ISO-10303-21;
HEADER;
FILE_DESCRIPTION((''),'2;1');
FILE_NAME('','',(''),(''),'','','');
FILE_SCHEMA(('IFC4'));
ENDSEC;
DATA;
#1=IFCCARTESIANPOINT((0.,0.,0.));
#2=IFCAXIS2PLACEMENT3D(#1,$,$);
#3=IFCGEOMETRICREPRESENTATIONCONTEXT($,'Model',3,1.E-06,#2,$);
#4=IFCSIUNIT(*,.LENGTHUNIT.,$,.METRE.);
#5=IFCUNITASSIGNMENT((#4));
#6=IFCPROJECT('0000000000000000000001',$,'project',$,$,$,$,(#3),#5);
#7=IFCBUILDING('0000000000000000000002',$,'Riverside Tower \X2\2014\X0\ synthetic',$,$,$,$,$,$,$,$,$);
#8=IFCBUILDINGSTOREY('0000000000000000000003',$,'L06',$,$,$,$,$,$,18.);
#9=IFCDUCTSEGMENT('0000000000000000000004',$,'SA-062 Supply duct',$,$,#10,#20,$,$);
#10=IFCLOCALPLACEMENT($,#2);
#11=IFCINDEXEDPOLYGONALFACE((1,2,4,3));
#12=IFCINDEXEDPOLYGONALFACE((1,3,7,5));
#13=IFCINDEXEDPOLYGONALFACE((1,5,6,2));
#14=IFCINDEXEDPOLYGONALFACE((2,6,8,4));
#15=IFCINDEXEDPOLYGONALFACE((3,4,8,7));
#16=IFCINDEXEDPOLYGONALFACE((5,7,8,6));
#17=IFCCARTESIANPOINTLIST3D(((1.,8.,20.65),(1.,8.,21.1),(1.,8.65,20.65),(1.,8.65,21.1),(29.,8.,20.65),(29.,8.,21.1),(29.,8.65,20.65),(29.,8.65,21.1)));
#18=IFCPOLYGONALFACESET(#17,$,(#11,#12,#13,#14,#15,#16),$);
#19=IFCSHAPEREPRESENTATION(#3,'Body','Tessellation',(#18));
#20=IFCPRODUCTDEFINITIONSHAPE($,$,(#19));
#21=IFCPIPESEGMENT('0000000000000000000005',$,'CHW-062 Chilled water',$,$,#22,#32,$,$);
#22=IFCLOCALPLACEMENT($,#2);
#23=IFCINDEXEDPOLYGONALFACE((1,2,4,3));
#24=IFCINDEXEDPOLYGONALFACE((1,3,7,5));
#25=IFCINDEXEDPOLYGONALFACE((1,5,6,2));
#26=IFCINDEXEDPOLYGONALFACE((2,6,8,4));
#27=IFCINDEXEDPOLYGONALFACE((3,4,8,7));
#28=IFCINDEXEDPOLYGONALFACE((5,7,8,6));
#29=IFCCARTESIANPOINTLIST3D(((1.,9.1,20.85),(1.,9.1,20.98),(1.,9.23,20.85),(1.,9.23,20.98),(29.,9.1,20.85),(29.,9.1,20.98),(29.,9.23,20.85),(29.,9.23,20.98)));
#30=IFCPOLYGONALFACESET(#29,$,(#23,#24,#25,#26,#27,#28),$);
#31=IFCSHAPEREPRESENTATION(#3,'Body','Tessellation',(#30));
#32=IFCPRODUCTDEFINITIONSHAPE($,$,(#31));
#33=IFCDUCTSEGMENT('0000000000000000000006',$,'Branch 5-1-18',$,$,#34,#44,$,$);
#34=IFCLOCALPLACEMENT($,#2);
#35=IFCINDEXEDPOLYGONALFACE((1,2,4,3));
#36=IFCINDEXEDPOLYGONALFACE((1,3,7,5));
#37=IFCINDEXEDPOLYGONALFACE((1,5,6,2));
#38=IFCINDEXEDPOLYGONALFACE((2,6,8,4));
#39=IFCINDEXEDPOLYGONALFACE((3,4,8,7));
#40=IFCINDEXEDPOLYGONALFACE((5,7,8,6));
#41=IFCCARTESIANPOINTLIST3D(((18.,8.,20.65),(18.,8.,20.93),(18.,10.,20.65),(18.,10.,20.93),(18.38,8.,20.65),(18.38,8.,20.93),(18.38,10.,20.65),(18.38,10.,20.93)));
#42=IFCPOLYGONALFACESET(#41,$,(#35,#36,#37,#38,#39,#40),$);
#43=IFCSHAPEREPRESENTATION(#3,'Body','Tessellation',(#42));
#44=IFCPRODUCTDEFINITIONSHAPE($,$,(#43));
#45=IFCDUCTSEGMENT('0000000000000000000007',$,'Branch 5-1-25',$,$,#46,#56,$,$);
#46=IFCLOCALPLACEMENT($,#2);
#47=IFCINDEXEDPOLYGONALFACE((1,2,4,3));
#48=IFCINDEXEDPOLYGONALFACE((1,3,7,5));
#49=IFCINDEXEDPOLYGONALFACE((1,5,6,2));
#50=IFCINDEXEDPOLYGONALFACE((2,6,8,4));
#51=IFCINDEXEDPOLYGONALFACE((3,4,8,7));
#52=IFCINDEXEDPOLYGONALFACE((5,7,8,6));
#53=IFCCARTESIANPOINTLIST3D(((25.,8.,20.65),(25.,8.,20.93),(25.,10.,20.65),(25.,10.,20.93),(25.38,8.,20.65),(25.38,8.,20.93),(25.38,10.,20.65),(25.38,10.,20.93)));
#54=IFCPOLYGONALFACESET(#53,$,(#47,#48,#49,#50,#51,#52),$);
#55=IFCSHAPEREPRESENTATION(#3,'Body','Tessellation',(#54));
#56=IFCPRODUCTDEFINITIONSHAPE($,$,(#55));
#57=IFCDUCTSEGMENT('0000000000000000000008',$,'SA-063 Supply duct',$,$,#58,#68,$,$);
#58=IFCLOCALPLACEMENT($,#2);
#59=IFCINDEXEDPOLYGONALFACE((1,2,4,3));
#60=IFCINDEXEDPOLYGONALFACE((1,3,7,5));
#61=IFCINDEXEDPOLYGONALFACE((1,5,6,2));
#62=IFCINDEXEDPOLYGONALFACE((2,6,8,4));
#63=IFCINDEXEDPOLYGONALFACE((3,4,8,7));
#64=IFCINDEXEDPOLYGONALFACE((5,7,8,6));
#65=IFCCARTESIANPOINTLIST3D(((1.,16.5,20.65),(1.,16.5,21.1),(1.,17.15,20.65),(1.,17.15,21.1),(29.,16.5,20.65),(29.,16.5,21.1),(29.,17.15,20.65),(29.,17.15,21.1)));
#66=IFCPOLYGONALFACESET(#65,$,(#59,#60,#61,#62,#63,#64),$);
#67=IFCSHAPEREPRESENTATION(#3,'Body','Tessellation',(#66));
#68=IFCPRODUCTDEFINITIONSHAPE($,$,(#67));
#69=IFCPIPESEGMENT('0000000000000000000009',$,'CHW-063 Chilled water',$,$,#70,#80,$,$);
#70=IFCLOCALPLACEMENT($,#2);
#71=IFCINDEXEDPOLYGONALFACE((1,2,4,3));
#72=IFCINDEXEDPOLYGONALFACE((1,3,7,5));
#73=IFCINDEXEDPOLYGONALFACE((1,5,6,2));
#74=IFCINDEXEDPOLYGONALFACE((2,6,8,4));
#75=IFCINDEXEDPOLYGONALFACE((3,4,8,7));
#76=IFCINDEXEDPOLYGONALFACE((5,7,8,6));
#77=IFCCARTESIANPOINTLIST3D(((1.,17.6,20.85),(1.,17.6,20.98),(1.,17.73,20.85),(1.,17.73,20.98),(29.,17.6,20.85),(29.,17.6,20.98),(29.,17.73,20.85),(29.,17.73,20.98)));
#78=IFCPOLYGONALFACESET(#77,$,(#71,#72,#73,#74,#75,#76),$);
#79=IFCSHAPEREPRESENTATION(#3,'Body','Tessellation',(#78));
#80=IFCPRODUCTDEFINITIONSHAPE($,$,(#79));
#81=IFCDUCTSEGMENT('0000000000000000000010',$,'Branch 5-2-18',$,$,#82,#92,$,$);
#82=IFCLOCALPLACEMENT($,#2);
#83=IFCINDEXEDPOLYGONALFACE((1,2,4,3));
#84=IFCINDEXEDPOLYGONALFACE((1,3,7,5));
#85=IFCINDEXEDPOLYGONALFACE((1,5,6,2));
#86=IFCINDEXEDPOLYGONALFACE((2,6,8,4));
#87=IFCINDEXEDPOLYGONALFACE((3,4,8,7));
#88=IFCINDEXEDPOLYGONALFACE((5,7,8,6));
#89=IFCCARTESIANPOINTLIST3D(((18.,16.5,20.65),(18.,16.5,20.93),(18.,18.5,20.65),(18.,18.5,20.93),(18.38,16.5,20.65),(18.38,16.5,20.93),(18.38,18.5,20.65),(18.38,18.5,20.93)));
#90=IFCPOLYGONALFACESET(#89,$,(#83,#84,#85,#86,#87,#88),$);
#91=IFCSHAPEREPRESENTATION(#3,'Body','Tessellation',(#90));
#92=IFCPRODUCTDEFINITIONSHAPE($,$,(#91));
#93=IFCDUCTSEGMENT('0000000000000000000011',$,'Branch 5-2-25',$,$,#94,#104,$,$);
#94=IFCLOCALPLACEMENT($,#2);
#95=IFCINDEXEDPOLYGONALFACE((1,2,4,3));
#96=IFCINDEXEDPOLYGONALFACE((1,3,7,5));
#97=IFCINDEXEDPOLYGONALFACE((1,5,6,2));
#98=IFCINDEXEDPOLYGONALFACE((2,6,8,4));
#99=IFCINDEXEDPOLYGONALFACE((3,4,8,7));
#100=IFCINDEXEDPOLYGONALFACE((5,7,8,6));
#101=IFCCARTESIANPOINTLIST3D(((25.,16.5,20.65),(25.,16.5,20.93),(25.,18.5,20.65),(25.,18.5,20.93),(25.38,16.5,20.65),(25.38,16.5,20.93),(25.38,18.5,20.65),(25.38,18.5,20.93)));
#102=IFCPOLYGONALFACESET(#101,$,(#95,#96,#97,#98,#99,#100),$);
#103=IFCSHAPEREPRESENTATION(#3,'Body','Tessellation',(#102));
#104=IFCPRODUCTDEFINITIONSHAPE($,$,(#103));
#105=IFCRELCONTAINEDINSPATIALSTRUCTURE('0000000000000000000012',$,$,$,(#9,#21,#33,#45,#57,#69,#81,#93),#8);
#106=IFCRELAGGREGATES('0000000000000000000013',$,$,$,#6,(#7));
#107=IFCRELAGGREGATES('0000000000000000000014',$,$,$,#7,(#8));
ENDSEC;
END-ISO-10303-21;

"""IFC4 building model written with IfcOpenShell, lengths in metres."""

from ifc_helpers import new_model, si_unit, frame, origin, place, context, project, spatial, rectangle, extrude, element, save


model = new_model("IFC4")

# Units and contexts
model_context = context("Model", 3, precision=1e-06, world=origin())
ifc_project = project(units=[si_unit("LENGTHUNIT", "METRE")], contexts=[model_context])

# Building, storey
building = spatial("IfcBuilding", under=ifc_project, Name="Riverside Tower — synthetic")
storey = spatial("IfcBuildingStorey", under=building, Name="L06", Elevation=18.0)

# Duct segment
duct_segment_1_placement = place(None, frame((15.0, 8.325, 20.65)))
element("IfcDuctSegment", 1, at=duct_segment_1_placement, inside=storey, Name="SA-062 Supply duct", context=model_context, shape_type="SweptSolid", body=[
    extrude(rectangle(XDim=28.0, YDim=0.65), origin(), (0.0, 0.0, 1.0), 0.45),
])

# Pipe segment
pipe_segment_1_placement = place(None, frame((15.0, 9.165, 20.85)))
element("IfcPipeSegment", 2, at=pipe_segment_1_placement, inside=storey, Name="CHW-062 Chilled water", context=model_context, shape_type="SweptSolid", body=[
    extrude(rectangle(XDim=28.0, YDim=0.13), origin(), (0.0, 0.0, 1.0), 0.13),
])

# Duct segments
for number, where, name in (
    (3, (18.19, 9.0, 20.65), "Branch 5-1-18"),
    (4, (25.19, 9.0, 20.65), "Branch 5-1-25"),
):
    element("IfcDuctSegment", number, at=place(None, frame(where)), inside=storey, Name=name, context=model_context, shape_type="SweptSolid", body=[
        extrude(rectangle(XDim=0.38, YDim=2.0), origin(), (0.0, 0.0, 1.0), 0.28),
    ])
duct_segment_2_placement = place(None, frame((15.0, 16.825, 20.65)))
element("IfcDuctSegment", 5, at=duct_segment_2_placement, inside=storey, Name="SA-063 Supply duct", context=model_context, shape_type="SweptSolid", body=[
    extrude(rectangle(XDim=28.0, YDim=0.65), origin(), (0.0, 0.0, 1.0), 0.45),
])

# Pipe segment
pipe_segment_2_placement = place(None, frame((15.0, 17.665, 20.85)))
element("IfcPipeSegment", 6, at=pipe_segment_2_placement, inside=storey, Name="CHW-063 Chilled water", context=model_context, shape_type="SweptSolid", body=[
    extrude(rectangle(XDim=28.0, YDim=0.13), origin(), (0.0, 0.0, 1.0), 0.13),
])

# Duct segments
for number, where, name in (
    (7, (18.19, 17.5, 20.65), "Branch 5-2-18"),
    (8, (25.19, 17.5, 20.65), "Branch 5-2-25"),
):
    element("IfcDuctSegment", number, at=place(None, frame(where)), inside=storey, Name=name, context=model_context, shape_type="SweptSolid", body=[
        extrude(rectangle(XDim=0.38, YDim=2.0), origin(), (0.0, 0.0, 1.0), 0.28),
    ])

save(model, "model.ifc")
